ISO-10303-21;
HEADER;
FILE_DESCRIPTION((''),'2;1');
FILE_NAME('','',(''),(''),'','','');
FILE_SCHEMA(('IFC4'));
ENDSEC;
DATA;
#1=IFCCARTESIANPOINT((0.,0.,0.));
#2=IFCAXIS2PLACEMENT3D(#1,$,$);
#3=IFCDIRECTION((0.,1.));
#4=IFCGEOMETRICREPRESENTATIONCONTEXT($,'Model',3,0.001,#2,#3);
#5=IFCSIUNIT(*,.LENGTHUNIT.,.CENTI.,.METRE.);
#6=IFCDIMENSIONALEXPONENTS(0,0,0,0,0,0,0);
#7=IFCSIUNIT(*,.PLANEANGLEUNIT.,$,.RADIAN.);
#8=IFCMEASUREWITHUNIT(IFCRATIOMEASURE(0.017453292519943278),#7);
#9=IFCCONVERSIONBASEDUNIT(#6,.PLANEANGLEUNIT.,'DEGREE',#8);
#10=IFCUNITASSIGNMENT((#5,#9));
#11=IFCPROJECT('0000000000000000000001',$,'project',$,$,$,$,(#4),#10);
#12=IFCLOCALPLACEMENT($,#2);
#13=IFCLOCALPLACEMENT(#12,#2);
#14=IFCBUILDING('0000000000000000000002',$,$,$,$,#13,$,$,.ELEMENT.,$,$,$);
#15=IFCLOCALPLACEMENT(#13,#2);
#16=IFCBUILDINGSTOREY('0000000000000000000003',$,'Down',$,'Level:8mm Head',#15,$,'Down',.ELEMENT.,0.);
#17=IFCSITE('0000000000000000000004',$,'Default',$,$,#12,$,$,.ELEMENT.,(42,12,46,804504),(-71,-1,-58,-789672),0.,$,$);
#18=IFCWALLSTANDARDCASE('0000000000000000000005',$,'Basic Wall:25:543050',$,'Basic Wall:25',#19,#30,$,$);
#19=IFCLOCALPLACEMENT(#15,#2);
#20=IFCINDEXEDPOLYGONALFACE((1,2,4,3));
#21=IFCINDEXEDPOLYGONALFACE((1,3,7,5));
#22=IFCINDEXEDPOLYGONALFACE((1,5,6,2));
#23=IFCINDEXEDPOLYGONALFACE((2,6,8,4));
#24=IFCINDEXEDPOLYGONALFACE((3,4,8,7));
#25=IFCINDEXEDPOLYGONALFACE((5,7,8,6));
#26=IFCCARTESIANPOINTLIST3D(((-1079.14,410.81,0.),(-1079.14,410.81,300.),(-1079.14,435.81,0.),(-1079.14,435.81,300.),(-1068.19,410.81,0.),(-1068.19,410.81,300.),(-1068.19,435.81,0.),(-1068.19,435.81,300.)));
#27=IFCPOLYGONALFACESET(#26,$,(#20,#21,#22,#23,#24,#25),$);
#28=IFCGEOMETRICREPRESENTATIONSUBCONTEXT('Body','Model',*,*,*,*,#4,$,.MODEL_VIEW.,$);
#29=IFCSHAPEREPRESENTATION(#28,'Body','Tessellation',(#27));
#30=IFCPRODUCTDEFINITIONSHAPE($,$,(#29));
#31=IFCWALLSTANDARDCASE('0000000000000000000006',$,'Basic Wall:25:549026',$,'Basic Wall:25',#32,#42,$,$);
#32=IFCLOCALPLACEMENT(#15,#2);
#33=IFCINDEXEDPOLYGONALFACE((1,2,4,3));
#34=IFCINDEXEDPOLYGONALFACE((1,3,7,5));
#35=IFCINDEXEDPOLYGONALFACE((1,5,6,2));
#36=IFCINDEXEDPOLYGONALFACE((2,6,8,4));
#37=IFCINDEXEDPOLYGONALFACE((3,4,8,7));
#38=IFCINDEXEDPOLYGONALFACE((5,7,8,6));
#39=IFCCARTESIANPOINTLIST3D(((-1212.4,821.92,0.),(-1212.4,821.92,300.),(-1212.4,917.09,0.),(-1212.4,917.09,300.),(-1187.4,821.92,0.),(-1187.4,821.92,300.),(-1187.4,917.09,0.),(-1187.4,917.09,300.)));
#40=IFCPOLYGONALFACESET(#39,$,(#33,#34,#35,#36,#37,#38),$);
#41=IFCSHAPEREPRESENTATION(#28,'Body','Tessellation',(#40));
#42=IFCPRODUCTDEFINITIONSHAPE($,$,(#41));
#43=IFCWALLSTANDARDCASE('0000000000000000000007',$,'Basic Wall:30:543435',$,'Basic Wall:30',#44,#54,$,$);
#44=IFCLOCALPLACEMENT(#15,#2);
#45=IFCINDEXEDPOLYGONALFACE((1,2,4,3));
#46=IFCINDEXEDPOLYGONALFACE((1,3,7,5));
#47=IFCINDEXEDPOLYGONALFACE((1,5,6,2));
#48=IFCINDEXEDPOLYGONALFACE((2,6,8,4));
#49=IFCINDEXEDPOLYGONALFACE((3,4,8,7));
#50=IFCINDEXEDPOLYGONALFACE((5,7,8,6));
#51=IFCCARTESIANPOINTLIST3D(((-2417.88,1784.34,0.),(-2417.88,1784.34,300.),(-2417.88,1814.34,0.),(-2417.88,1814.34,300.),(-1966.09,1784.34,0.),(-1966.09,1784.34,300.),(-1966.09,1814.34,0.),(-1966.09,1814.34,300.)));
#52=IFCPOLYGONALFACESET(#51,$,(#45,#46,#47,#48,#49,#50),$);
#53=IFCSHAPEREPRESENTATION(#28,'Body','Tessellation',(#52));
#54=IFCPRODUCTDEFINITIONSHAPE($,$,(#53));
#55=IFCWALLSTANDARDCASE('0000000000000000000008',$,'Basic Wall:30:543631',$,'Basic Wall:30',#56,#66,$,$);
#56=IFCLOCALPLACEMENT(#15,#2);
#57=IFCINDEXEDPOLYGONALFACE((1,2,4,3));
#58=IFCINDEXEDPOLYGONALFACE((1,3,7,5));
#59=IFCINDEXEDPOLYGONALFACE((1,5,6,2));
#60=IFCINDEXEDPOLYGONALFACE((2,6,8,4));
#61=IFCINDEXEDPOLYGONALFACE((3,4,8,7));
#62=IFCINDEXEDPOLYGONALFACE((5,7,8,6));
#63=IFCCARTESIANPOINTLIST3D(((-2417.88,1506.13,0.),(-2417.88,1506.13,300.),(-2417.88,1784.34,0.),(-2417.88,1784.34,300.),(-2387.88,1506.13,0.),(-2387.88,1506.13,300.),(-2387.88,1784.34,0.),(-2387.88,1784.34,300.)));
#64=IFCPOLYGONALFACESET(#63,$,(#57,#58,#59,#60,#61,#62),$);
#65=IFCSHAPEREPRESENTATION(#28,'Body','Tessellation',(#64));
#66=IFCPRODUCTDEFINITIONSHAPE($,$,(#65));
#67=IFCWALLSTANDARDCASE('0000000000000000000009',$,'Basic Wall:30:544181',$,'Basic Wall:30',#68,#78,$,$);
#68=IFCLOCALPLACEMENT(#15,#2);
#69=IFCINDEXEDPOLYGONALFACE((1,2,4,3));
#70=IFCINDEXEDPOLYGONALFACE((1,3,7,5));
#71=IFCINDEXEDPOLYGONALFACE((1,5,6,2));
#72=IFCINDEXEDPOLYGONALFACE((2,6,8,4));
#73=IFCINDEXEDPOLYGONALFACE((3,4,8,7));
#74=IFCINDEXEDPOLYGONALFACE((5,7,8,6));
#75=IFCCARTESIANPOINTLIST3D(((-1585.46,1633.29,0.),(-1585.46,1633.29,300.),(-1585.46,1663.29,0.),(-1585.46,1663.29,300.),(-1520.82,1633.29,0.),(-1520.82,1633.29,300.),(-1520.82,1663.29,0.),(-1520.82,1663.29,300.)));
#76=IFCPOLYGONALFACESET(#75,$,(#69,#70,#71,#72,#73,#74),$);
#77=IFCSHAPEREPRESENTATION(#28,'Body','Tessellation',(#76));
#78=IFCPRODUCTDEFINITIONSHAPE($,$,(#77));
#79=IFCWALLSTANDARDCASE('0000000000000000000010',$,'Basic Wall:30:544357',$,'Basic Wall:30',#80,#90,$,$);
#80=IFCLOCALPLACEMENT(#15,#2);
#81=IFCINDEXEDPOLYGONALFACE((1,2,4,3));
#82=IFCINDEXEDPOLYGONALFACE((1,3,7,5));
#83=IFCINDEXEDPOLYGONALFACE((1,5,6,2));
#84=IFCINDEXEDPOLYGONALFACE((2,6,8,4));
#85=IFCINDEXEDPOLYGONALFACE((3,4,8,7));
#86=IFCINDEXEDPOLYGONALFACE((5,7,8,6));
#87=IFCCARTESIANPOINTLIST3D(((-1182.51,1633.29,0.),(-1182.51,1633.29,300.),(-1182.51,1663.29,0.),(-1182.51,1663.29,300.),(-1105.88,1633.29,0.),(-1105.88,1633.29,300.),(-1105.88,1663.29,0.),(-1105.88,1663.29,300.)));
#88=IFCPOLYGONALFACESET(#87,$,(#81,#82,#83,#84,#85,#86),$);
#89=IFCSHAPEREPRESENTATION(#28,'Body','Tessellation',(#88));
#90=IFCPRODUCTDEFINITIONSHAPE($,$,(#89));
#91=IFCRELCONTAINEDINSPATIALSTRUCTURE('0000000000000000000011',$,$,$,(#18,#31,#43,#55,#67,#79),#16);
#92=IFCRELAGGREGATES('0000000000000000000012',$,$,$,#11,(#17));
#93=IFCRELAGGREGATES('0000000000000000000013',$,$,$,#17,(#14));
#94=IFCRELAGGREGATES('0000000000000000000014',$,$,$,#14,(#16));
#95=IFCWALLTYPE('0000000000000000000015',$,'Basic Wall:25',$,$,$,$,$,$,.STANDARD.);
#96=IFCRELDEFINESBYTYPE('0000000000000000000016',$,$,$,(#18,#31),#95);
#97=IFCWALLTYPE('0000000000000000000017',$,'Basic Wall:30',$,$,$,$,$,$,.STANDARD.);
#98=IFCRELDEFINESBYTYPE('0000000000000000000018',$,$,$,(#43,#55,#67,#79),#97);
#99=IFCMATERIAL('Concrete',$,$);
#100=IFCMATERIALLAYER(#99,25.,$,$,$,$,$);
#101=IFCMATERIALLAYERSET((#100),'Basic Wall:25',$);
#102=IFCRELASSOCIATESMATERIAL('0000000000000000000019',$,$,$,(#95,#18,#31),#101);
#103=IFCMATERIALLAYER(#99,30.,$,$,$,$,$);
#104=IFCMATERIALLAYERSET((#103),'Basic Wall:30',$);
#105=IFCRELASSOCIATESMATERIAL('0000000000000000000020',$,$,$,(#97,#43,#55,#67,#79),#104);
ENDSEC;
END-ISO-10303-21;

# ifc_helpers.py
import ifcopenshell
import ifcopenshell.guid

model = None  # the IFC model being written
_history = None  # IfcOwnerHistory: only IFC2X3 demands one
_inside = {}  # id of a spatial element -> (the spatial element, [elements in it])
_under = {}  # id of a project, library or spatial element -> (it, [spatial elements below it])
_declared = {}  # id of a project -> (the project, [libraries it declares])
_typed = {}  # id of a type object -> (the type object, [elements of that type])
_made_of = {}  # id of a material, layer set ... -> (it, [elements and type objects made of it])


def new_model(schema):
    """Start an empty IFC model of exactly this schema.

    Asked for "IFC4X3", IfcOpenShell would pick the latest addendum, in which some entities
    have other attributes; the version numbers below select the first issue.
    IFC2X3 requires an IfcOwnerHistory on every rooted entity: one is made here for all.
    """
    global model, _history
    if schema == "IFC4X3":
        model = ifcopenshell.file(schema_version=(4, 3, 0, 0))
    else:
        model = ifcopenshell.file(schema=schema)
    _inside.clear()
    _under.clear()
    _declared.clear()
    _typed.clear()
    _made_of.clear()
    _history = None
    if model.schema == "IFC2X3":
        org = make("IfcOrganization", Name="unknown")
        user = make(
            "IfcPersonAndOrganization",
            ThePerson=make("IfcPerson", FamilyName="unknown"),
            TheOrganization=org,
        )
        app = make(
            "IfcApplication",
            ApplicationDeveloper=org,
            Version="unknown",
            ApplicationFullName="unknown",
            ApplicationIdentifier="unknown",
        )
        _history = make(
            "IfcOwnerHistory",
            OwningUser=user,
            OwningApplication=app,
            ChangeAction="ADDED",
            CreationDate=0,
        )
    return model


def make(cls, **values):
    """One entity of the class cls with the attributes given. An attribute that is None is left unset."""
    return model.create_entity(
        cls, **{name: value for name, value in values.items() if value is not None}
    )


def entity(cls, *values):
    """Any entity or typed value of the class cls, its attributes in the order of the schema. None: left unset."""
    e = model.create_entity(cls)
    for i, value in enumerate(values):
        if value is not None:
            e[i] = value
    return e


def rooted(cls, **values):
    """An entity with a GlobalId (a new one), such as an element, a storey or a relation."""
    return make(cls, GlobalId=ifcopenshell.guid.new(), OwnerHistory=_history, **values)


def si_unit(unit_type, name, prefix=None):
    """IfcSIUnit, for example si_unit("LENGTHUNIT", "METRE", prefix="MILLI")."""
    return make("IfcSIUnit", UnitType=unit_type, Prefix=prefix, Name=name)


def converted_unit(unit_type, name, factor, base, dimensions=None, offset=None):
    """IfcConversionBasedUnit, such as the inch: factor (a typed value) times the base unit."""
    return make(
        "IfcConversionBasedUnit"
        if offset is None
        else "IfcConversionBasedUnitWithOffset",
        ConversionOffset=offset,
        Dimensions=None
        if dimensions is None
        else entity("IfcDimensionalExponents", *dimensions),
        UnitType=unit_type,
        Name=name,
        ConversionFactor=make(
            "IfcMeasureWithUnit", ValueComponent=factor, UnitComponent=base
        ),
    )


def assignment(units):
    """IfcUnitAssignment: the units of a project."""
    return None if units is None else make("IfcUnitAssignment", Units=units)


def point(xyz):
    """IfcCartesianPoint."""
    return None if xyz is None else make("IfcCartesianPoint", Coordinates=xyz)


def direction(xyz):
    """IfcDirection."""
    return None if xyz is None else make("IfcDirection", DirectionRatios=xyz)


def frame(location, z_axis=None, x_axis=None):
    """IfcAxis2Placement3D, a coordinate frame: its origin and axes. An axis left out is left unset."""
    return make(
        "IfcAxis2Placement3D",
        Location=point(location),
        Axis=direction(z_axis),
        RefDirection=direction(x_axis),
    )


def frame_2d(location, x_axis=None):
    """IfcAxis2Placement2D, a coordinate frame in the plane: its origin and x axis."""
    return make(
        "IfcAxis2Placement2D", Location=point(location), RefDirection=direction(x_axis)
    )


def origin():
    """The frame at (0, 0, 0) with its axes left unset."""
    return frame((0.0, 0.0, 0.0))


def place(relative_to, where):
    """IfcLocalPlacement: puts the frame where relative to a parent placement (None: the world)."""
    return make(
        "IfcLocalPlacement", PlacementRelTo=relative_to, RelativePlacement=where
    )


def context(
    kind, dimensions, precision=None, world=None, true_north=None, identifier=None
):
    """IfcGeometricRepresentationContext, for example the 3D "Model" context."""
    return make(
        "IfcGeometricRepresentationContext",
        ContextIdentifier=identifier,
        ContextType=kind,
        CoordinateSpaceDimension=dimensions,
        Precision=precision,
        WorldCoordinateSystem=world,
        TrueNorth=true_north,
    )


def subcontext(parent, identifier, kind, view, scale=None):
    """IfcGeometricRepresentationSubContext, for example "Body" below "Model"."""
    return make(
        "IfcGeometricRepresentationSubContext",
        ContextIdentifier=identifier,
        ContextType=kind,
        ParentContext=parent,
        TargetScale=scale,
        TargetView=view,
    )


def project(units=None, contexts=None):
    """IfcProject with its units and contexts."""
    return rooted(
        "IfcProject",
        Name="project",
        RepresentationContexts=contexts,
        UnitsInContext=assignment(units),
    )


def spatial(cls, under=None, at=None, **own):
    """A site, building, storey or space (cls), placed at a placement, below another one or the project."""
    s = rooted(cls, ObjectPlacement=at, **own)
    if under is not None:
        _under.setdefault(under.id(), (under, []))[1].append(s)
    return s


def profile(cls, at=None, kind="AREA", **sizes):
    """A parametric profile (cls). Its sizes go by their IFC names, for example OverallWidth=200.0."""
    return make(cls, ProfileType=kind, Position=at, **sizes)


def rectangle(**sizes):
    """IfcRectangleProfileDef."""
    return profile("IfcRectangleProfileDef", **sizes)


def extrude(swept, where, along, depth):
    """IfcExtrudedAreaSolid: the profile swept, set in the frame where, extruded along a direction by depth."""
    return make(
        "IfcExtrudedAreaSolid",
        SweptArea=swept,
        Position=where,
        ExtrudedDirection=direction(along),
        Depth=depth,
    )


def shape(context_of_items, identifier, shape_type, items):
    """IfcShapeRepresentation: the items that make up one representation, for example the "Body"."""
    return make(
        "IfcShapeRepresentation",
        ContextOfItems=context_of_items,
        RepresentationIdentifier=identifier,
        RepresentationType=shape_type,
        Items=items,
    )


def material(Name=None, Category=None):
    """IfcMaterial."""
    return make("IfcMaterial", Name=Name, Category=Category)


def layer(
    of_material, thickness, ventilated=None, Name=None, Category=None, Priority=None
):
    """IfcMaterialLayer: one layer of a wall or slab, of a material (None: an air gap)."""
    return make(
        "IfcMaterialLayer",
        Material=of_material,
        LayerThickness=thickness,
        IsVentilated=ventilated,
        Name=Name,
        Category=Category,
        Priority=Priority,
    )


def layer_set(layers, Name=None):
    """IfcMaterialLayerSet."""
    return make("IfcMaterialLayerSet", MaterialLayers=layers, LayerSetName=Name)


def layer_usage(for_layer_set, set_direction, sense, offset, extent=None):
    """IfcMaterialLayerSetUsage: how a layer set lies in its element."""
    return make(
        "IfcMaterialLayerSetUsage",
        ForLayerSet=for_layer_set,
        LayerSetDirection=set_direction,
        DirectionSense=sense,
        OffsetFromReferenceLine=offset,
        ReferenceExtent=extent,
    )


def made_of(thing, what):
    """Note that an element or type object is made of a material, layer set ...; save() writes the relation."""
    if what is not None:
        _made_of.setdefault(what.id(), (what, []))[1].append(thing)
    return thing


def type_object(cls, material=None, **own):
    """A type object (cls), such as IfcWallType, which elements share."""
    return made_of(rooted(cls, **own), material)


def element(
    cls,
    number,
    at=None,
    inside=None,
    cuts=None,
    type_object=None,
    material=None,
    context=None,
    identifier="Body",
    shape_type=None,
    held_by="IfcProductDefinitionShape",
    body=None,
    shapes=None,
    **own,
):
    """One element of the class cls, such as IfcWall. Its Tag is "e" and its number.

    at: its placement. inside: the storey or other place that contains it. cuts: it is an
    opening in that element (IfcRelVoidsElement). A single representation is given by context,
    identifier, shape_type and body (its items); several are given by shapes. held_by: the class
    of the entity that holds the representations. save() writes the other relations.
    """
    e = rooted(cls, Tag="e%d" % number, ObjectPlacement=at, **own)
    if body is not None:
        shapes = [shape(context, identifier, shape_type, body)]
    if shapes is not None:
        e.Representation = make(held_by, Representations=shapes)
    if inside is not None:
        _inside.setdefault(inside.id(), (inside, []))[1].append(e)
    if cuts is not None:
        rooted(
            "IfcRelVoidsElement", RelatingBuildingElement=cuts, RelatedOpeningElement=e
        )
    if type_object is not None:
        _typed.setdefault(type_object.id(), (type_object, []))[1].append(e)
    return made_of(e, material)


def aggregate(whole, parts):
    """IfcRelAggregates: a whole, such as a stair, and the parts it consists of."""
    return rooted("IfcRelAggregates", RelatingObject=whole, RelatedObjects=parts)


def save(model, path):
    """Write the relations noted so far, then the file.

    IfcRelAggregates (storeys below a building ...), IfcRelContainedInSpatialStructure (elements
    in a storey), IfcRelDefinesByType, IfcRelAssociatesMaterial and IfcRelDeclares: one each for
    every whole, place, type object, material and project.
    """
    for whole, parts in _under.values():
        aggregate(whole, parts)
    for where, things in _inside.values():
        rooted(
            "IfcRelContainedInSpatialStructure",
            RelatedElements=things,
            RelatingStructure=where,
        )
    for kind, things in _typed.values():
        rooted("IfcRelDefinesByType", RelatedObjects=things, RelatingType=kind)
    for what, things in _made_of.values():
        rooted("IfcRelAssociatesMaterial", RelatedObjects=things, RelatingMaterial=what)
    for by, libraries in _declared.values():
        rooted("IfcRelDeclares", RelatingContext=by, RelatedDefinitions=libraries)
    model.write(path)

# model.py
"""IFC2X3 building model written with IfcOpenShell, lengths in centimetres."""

from ifc_helpers import new_model, entity, si_unit, converted_unit, direction, frame, frame_2d, origin, place, context, subcontext, project, spatial, rectangle, extrude, material, layer, layer_set, layer_usage, type_object, element, save


model = new_model("IFC2X3")

# Units and contexts
model_context = context("Model", 3, precision=0.001, world=origin(), true_north=direction((0.0, 1.0)))
body_context = subcontext(model_context, "Body", "Model", "MODEL_VIEW")
ifc_project = project(units=[si_unit("LENGTHUNIT", "METRE", prefix="CENTI"), converted_unit("PLANEANGLEUNIT", "DEGREE", entity("IfcRatioMeasure", 0.017453292519943278), si_unit("PLANEANGLEUNIT", "RADIAN"), dimensions=[0, 0, 0, 0, 0, 0, 0])], contexts=[model_context])

# Site, building, storey
site_placement = place(None, origin())
site = spatial("IfcSite", under=ifc_project, at=site_placement, Name="Default", CompositionType="ELEMENT", RefLatitude=(42, 12, 46, 804504), RefLongitude=(-71, -1, -58, -789672), RefElevation=0.0)
building_placement = place(site_placement, origin())
building = spatial("IfcBuilding", under=site, at=building_placement, CompositionType="ELEMENT")
storey_placement = place(building_placement, origin())
storey = spatial("IfcBuildingStorey", under=building, at=storey_placement, Name="Down", ObjectType="Level:8mm Head", LongName="Down", CompositionType="ELEMENT", Elevation=0.0)

# Walls
ifc_material = material(Name="Concrete")
ifc_layer_1 = layer(ifc_material, 25.0)
ifc_layer_set_1 = layer_set([ifc_layer_1], Name="Basic Wall:25")
wall_type_1 = type_object("IfcWallType", Name="Basic Wall:25", PredefinedType="STANDARD", material=ifc_layer_set_1)
ifc_layer_usage_1 = layer_usage(ifc_layer_set_1, "AXIS2", "POSITIVE", -12.5)
wall_1_placement = place(storey_placement, frame((-1068.19, 423.31, 0.0), z_axis=(0.0, 0.0, 1.0), x_axis=(-1.0, 0.0, 0.0)))
element("IfcWallStandardCase", 1, at=wall_1_placement, inside=storey, type_object=wall_type_1, material=ifc_layer_usage_1, Name="Basic Wall:25:543050", ObjectType="Basic Wall:25", context=body_context, shape_type="SweptSolid", body=[
    extrude(rectangle(XDim=10.95, YDim=25.0, at=frame_2d((5.47, 0.0), x_axis=(-1.0, 0.0))), origin(), (0.0, 0.0, 1.0), 300.0),
])
ifc_layer_usage_2 = layer_usage(ifc_layer_set_1, "AXIS2", "POSITIVE", -12.5)
wall_2_placement = place(storey_placement, frame((-1199.9, 917.09, 0.0), z_axis=(0.0, 0.0, 1.0), x_axis=(0.0, -1.0, 0.0)))
element("IfcWallStandardCase", 2, at=wall_2_placement, inside=storey, type_object=wall_type_1, material=ifc_layer_usage_2, Name="Basic Wall:25:549026", ObjectType="Basic Wall:25", context=body_context, shape_type="SweptSolid", body=[
    extrude(rectangle(XDim=95.17, YDim=25.0, at=frame_2d((47.59, 0.0), x_axis=(-1.0, 0.0))), origin(), (0.0, 0.0, 1.0), 300.0),
])
ifc_layer_2 = layer(ifc_material, 30.0)
ifc_layer_set_2 = layer_set([ifc_layer_2], Name="Basic Wall:30")
ifc_layer_usage_3 = layer_usage(ifc_layer_set_2, "AXIS2", "POSITIVE", -15.0)
wall_type_2 = type_object("IfcWallType", Name="Basic Wall:30", PredefinedType="STANDARD", material=ifc_layer_set_2)
wall_3_placement = place(storey_placement, frame((-1966.09, 1799.34, 0.0), z_axis=(0.0, 0.0, 1.0), x_axis=(-1.0, 0.0, 0.0)))
element("IfcWallStandardCase", 3, at=wall_3_placement, inside=storey, type_object=wall_type_2, material=ifc_layer_usage_3, Name="Basic Wall:30:543435", ObjectType="Basic Wall:30", context=body_context, shape_type="SweptSolid", body=[
    extrude(rectangle(XDim=451.79, YDim=30.0, at=frame_2d((225.89, 0.0), x_axis=(-1.0, 0.0))), origin(), (0.0, 0.0, 1.0), 300.0),
])
ifc_layer_usage_4 = layer_usage(ifc_layer_set_2, "AXIS2", "POSITIVE", -15.0)
wall_4_placement = place(storey_placement, frame((-2402.88, 1784.34, 0.0), z_axis=(0.0, 0.0, 1.0), x_axis=(0.0, -1.0, 0.0)))
element("IfcWallStandardCase", 4, at=wall_4_placement, inside=storey, type_object=wall_type_2, material=ifc_layer_usage_4, Name="Basic Wall:30:543631", ObjectType="Basic Wall:30", context=body_context, shape_type="SweptSolid", body=[
    extrude(rectangle(XDim=278.21, YDim=30.0, at=frame_2d((139.11, 0.0), x_axis=(-1.0, 0.0))), origin(), (0.0, 0.0, 1.0), 300.0),
])
ifc_layer_usage_5 = layer_usage(ifc_layer_set_2, "AXIS2", "POSITIVE", -15.0)
wall_5_placement = place(storey_placement, frame((-1585.46, 1648.29, 0.0)))
element("IfcWallStandardCase", 5, at=wall_5_placement, inside=storey, type_object=wall_type_2, material=ifc_layer_usage_5, Name="Basic Wall:30:544181", ObjectType="Basic Wall:30", context=body_context, shape_type="SweptSolid", body=[
    extrude(rectangle(XDim=64.63, YDim=30.0, at=frame_2d((32.32, 0.0), x_axis=(-1.0, 0.0))), origin(), (0.0, 0.0, 1.0), 300.0),
])
ifc_layer_usage_6 = layer_usage(ifc_layer_set_2, "AXIS2", "POSITIVE", -15.0)
wall_6_placement = place(storey_placement, frame((-1182.51, 1648.29, 0.0)))
element("IfcWallStandardCase", 6, at=wall_6_placement, inside=storey, type_object=wall_type_2, material=ifc_layer_usage_6, Name="Basic Wall:30:544357", ObjectType="Basic Wall:30", context=body_context, shape_type="SweptSolid", body=[
    extrude(rectangle(XDim=76.63, YDim=30.0, at=frame_2d((38.32, 0.0), x_axis=(-1.0, 0.0))), origin(), (0.0, 0.0, 1.0), 300.0),
])

save(model, "model.ifc")
